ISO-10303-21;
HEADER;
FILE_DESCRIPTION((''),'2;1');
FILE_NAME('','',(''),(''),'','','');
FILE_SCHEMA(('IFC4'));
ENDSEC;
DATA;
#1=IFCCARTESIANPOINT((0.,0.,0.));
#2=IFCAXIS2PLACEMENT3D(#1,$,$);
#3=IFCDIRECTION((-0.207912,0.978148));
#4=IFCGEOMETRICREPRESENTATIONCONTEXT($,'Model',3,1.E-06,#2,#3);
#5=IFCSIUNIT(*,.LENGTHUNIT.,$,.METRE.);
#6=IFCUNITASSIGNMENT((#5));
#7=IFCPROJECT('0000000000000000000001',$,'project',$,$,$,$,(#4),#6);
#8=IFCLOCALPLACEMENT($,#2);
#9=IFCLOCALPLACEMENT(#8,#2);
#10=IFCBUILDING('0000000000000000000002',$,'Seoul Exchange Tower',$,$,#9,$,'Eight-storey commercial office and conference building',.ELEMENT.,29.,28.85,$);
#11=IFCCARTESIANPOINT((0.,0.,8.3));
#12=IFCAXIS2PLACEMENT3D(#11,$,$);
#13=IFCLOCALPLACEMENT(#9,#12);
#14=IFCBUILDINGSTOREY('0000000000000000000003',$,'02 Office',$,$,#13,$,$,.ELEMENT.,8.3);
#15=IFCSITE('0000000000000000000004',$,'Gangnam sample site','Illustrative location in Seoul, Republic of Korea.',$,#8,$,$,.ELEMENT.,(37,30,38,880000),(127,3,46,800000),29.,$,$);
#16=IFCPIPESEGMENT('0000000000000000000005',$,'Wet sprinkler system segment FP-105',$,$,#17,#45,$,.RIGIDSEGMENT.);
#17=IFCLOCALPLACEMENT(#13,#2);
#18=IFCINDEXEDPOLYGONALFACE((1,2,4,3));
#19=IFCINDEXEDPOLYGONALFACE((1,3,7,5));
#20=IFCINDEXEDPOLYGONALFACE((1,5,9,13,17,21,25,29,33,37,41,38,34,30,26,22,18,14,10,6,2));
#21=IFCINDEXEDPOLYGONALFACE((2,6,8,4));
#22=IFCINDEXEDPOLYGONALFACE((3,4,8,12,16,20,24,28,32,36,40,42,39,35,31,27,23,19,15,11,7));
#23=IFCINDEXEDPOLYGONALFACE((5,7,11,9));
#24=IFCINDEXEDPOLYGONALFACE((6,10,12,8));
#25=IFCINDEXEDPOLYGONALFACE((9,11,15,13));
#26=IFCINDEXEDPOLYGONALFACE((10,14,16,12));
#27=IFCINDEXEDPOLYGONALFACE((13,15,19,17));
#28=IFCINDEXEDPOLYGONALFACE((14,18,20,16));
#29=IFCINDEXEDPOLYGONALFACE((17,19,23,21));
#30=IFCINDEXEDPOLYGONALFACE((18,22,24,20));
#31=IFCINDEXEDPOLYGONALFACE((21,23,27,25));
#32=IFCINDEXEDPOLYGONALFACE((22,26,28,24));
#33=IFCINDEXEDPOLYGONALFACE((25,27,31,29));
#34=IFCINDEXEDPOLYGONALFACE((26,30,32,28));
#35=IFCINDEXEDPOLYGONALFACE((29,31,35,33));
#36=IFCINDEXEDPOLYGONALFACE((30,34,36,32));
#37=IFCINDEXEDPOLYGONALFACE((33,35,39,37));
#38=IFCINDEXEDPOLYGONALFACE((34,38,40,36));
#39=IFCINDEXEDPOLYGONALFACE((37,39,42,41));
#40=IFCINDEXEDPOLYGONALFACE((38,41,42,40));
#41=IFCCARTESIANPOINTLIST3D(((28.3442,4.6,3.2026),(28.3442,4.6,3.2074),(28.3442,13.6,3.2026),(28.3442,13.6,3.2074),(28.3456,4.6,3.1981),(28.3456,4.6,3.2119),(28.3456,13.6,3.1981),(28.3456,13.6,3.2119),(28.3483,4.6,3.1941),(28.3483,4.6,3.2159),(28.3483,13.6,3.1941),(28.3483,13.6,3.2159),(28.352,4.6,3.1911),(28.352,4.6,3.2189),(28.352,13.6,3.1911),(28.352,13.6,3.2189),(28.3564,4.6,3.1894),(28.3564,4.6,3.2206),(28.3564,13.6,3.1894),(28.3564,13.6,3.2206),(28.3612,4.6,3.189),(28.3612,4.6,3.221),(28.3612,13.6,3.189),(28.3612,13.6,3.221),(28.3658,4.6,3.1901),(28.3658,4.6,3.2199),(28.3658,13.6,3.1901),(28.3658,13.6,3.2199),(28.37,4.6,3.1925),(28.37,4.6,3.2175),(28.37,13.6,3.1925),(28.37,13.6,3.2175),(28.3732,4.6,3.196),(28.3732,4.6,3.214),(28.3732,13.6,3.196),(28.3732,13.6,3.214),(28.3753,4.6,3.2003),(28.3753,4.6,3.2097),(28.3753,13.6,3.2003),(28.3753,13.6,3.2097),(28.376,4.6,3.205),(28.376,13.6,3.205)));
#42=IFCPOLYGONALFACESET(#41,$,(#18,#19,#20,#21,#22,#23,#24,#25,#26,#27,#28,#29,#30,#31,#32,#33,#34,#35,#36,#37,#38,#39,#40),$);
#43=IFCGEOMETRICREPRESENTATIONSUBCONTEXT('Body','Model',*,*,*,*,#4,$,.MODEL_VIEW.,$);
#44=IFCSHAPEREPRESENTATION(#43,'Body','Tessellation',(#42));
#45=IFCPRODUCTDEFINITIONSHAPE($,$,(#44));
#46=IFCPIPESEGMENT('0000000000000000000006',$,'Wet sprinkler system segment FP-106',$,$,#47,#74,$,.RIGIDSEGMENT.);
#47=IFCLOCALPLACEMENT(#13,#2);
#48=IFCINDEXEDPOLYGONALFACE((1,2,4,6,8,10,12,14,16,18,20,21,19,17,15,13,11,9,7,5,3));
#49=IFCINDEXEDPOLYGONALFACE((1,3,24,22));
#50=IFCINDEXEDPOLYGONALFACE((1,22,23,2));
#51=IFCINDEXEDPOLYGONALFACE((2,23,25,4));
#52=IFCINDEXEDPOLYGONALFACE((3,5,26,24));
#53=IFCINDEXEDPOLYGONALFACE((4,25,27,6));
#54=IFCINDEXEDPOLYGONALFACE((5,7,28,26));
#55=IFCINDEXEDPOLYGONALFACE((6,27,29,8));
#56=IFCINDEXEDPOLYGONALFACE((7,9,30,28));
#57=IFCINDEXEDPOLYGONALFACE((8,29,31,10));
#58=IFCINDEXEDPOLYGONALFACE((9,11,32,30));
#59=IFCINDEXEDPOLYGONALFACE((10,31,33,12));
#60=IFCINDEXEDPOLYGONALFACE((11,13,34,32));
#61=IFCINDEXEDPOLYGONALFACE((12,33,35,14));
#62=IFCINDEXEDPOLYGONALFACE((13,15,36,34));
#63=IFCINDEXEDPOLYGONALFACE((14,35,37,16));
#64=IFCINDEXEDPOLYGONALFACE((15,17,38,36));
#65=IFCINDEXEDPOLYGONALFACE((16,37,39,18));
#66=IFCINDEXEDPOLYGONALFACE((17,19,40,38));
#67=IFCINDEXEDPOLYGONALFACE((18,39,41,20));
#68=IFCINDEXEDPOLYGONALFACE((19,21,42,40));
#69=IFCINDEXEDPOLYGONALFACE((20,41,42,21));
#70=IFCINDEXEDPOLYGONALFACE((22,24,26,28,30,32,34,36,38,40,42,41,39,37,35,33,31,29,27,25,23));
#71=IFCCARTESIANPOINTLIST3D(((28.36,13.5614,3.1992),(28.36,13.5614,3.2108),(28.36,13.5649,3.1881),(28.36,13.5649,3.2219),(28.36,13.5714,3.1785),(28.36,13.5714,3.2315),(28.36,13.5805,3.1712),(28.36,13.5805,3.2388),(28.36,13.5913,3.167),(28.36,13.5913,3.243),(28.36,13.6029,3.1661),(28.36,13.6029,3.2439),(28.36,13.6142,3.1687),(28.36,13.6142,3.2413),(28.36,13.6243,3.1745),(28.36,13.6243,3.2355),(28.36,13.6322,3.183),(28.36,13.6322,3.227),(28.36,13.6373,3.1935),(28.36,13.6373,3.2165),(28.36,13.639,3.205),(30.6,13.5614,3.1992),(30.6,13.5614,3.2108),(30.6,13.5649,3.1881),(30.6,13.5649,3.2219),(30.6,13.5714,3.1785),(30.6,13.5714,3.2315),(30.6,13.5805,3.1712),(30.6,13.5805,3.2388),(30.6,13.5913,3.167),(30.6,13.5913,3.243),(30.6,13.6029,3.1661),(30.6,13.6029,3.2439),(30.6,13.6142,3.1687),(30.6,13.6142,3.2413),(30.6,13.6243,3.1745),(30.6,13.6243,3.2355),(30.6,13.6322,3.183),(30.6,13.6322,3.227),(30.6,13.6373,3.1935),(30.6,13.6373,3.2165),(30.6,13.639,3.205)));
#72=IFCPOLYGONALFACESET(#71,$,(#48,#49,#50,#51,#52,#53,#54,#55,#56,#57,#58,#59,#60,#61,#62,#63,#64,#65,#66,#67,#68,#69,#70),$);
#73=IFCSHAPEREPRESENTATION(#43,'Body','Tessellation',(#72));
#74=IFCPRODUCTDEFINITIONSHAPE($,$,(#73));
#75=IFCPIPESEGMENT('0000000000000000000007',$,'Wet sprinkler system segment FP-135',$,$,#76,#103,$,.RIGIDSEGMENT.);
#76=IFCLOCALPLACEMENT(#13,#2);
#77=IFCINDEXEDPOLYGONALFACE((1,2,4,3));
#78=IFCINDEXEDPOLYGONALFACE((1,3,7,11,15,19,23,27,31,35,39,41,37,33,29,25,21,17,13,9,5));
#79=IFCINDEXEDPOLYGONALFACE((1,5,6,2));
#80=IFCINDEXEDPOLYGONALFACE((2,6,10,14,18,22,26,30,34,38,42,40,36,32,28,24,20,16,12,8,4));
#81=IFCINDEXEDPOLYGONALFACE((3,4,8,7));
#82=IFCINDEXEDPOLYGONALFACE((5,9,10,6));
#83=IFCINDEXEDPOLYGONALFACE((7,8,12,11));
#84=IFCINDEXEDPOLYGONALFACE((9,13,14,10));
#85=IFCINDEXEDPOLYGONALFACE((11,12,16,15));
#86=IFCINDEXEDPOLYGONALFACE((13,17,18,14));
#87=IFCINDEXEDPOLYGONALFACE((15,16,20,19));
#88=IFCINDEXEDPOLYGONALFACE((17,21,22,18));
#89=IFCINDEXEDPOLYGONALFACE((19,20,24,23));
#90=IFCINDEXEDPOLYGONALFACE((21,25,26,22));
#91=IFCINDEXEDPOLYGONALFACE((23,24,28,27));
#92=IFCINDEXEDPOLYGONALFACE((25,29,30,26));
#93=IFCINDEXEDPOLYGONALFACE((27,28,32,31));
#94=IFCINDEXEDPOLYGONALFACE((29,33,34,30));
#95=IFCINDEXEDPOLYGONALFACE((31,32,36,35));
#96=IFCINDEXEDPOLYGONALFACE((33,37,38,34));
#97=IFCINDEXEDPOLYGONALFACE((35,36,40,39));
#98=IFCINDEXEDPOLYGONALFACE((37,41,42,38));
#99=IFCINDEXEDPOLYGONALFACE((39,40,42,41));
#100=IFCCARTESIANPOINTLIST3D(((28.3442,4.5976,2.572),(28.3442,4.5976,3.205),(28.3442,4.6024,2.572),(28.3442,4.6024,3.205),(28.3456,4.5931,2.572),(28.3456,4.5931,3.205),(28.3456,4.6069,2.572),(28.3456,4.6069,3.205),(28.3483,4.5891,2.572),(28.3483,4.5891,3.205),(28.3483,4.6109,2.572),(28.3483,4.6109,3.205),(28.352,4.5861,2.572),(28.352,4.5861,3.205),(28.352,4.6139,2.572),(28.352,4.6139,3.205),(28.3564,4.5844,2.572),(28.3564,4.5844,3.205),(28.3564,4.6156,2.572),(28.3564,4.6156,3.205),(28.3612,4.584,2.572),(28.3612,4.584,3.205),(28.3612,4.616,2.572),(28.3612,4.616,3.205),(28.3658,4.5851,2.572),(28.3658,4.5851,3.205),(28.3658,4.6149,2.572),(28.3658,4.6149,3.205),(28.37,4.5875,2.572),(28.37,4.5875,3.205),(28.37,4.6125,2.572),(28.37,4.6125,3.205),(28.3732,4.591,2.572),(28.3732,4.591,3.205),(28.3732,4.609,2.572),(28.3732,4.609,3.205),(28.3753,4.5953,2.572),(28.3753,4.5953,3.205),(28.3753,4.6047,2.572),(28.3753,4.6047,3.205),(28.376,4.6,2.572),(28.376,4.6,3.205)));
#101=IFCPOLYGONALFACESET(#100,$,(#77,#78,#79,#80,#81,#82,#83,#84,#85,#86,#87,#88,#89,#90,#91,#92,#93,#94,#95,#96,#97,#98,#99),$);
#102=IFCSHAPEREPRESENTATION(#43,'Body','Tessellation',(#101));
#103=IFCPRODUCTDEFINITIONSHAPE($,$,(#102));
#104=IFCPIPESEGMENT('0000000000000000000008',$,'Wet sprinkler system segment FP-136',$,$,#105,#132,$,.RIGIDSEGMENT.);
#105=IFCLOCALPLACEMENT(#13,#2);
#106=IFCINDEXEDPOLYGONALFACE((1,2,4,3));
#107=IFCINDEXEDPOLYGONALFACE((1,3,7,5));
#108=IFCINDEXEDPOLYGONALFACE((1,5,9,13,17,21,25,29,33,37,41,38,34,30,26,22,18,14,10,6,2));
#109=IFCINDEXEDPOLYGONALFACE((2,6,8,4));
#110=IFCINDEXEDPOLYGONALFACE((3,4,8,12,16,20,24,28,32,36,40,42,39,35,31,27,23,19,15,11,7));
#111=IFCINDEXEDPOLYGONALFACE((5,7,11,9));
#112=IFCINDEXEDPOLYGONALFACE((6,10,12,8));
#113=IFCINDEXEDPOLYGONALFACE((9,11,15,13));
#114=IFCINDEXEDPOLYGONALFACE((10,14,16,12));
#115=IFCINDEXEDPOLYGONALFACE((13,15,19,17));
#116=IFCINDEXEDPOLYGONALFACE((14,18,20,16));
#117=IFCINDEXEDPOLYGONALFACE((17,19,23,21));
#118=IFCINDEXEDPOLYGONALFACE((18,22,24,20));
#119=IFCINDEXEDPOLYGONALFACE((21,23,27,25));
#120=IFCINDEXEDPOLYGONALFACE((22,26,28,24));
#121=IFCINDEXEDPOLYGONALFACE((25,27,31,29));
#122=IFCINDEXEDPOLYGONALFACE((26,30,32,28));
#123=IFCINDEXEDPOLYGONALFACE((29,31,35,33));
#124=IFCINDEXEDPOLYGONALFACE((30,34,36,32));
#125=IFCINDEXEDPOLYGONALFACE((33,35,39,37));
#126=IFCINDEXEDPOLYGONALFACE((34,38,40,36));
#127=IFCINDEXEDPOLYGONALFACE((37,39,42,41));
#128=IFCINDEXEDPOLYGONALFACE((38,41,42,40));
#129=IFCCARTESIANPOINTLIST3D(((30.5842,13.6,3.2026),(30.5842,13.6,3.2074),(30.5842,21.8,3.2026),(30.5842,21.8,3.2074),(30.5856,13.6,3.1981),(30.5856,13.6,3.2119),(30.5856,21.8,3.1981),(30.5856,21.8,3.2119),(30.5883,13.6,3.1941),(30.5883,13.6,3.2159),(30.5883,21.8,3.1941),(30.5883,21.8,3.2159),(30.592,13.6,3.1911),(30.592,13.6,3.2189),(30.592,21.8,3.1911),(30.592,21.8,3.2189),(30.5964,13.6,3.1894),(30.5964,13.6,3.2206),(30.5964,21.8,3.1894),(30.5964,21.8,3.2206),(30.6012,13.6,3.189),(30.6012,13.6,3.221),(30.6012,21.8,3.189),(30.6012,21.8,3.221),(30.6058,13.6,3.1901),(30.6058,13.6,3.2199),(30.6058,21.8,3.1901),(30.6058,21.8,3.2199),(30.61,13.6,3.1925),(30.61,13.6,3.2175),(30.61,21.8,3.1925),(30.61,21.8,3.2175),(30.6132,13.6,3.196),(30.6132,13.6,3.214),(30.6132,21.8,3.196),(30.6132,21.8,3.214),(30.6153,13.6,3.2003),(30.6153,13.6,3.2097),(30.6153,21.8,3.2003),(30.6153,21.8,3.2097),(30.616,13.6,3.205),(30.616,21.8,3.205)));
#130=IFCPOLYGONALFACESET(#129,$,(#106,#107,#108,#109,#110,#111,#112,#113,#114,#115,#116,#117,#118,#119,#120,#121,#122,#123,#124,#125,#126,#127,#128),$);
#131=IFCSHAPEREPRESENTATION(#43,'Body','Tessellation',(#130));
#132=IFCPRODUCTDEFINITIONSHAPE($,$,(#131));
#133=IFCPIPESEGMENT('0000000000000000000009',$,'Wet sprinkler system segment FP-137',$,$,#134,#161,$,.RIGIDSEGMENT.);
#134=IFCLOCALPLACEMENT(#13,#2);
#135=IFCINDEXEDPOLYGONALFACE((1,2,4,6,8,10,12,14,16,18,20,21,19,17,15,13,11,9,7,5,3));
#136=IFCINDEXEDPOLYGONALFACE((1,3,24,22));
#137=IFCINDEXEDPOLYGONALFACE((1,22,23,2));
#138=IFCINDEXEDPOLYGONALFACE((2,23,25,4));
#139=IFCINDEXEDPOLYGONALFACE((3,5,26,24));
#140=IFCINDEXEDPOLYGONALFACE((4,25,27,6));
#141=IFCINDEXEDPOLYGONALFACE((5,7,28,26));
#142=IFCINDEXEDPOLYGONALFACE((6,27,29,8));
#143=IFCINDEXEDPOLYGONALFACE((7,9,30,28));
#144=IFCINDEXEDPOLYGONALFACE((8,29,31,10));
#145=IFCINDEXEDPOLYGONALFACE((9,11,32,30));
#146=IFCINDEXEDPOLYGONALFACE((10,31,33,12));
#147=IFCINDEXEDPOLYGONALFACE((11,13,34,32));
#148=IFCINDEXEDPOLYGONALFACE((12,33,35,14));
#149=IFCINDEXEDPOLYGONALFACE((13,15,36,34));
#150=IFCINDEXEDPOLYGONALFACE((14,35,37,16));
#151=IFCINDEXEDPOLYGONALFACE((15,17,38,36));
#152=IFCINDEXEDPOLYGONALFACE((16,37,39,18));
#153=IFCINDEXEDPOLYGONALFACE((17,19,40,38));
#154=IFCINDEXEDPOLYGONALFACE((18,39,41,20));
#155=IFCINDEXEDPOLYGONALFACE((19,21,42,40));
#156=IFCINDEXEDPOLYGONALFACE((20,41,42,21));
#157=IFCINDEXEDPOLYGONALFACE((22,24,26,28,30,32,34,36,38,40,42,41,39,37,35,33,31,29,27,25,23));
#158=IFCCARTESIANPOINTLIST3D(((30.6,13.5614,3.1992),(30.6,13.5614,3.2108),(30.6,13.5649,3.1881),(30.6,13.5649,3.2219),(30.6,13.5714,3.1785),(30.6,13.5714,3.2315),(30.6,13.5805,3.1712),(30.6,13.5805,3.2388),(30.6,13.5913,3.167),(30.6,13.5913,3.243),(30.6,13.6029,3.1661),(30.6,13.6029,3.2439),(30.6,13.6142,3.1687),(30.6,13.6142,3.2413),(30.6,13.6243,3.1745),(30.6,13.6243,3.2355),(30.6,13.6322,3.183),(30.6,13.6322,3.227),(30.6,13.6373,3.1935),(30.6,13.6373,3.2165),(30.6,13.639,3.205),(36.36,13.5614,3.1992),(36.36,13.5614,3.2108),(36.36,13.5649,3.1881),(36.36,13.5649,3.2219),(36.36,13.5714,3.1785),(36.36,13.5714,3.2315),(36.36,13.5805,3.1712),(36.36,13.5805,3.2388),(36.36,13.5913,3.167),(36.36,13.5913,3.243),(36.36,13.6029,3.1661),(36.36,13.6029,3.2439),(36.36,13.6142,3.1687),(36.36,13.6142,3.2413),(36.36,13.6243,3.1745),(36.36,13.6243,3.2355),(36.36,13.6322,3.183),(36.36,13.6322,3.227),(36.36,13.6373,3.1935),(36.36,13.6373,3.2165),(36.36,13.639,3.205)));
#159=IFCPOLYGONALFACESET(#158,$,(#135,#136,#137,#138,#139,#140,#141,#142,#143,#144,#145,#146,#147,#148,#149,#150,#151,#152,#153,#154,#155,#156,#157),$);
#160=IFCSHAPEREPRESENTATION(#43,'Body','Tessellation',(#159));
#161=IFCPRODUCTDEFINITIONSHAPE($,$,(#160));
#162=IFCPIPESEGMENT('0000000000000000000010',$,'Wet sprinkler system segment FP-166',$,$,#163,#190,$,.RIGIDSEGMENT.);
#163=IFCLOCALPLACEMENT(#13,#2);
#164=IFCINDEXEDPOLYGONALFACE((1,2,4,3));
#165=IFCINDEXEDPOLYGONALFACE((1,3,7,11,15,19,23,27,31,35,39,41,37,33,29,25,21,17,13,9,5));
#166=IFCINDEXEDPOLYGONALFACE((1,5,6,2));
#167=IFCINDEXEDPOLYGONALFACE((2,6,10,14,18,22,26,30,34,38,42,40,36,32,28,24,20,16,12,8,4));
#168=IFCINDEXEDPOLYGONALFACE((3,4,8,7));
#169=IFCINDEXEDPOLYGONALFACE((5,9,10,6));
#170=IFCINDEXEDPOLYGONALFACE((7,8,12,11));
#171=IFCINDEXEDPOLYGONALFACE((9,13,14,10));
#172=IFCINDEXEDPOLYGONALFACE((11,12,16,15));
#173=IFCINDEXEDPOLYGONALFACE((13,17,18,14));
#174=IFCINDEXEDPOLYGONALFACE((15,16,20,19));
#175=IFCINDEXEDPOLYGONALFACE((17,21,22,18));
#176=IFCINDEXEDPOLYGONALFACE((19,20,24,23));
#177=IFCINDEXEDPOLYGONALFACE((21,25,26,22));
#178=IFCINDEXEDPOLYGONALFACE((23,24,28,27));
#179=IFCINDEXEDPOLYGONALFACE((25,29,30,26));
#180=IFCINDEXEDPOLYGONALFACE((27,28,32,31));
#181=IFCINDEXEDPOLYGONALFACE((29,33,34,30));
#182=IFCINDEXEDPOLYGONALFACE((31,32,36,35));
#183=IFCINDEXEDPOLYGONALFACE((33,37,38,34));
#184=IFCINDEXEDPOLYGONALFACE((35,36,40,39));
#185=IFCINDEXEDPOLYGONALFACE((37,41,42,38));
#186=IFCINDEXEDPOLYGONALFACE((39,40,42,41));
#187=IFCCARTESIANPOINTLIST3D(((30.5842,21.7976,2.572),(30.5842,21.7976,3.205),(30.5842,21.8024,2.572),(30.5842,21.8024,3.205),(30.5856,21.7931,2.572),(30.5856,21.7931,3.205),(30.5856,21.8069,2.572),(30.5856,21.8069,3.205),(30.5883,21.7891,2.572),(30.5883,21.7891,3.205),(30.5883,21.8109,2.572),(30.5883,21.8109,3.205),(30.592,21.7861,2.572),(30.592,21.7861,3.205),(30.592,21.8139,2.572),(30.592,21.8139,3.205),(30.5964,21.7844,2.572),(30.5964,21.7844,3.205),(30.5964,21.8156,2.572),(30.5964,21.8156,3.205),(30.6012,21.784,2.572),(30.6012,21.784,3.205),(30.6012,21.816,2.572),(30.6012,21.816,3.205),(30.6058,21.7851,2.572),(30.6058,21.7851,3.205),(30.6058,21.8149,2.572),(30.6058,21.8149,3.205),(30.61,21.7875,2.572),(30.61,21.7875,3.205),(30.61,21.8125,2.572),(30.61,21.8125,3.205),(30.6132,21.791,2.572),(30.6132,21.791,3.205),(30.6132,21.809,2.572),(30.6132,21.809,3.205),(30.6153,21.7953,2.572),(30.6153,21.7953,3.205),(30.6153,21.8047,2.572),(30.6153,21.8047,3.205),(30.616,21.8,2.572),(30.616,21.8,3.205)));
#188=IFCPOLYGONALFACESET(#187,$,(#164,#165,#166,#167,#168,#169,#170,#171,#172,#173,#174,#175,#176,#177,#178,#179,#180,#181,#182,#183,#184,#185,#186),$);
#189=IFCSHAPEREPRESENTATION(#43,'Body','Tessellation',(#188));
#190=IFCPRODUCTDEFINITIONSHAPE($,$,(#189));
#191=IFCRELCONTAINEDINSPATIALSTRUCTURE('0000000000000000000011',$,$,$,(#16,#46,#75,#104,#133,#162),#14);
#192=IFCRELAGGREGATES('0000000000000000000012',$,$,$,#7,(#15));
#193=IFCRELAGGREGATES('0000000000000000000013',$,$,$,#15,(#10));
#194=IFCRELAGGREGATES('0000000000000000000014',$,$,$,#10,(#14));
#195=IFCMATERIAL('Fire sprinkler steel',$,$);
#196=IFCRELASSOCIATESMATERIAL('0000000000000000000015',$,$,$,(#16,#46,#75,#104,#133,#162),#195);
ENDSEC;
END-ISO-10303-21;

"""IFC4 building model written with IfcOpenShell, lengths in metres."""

from ifc_helpers import new_model, si_unit, direction, frame, origin, place, context, subcontext, project, spatial, circle, extrude, material, element, save


model = new_model("IFC4")

# Units and contexts
model_context = context("Model", 3, precision=1e-06, world=origin(), true_north=direction((-0.207912, 0.978148)))
body_context = subcontext(model_context, "Body", "Model", "MODEL_VIEW")
ifc_project = project(units=[si_unit("LENGTHUNIT", "METRE")], contexts=[model_context])

# Site, building, storey
site_placement = place(None, origin())
site = spatial("IfcSite", under=ifc_project, at=site_placement, Name="Gangnam sample site", Description="Illustrative location in Seoul, Republic of Korea.", CompositionType="ELEMENT", RefLatitude=(37, 30, 38, 880000), RefLongitude=(127, 3, 46, 800000), RefElevation=29.0)
building_placement = place(site_placement, origin())
building = spatial("IfcBuilding", under=site, at=building_placement, Name="Seoul Exchange Tower", LongName="Eight-storey commercial office and conference building", CompositionType="ELEMENT", ElevationOfRefHeight=29.0, ElevationOfTerrain=28.85)
storey_placement = place(building_placement, frame((0.0, 0.0, 8.3)))
storey = spatial("IfcBuildingStorey", under=building, at=storey_placement, Name="02 Office", CompositionType="ELEMENT", Elevation=8.3)

# Shared definitions
ifc_material = material(Name="Fire sprinkler steel")
placement = place(storey_placement, origin())

# Pipe segments
element("IfcPipeSegment", 1, at=placement, inside=storey, material=ifc_material, Name="Wet sprinkler system segment FP-105", PredefinedType="RIGIDSEGMENT", context=body_context, shape_type="SweptSolid", body=[
    extrude(circle(Radius=0.016), frame((28.36, 13.6, 3.205), z_axis=(0.0, -1.0, 0.0), x_axis=(1.0, 0.0, 0.0)), (0.0, 0.0, 1.0), 9.0),
])
element("IfcPipeSegment", 2, at=placement, inside=storey, material=ifc_material, Name="Wet sprinkler system segment FP-106", PredefinedType="RIGIDSEGMENT", context=body_context, shape_type="SweptSolid", body=[
    extrude(circle(Radius=0.039), frame((28.36, 13.6, 3.205), z_axis=(1.0, 0.0, 0.0), x_axis=(0.0, 1.0, 0.0)), (0.0, 0.0, 1.0), 2.24),
])
element("IfcPipeSegment", 3, at=placement, inside=storey, material=ifc_material, Name="Wet sprinkler system segment FP-135", PredefinedType="RIGIDSEGMENT", context=body_context, shape_type="SweptSolid", body=[
    extrude(circle(Radius=0.016), frame((28.36, 4.6, 3.205), z_axis=(0.0, 0.0, -1.0), x_axis=(1.0, 0.0, 0.0)), (0.0, 0.0, 1.0), 0.633),
])
element("IfcPipeSegment", 4, at=placement, inside=storey, material=ifc_material, Name="Wet sprinkler system segment FP-136", PredefinedType="RIGIDSEGMENT", context=body_context, shape_type="SweptSolid", body=[
    extrude(circle(Radius=0.016), frame((30.6, 13.6, 3.205), z_axis=(0.0, 1.0, 0.0), x_axis=(1.0, 0.0, 0.0)), (0.0, 0.0, 1.0), 8.2),
])
element("IfcPipeSegment", 5, at=placement, inside=storey, material=ifc_material, Name="Wet sprinkler system segment FP-137", PredefinedType="RIGIDSEGMENT", context=body_context, shape_type="SweptSolid", body=[
    extrude(circle(Radius=0.039), frame((30.6, 13.6, 3.205), z_axis=(1.0, 0.0, 0.0), x_axis=(0.0, 1.0, 0.0)), (0.0, 0.0, 1.0), 5.76),
])
element("IfcPipeSegment", 6, at=placement, inside=storey, material=ifc_material, Name="Wet sprinkler system segment FP-166", PredefinedType="RIGIDSEGMENT", context=body_context, shape_type="SweptSolid", body=[
    extrude(circle(Radius=0.016), frame((30.6, 21.8, 3.205), z_axis=(0.0, 0.0, -1.0), x_axis=(1.0, 0.0, 0.0)), (0.0, 0.0, 1.0), 0.633),
])

save(model, "model.ifc")
